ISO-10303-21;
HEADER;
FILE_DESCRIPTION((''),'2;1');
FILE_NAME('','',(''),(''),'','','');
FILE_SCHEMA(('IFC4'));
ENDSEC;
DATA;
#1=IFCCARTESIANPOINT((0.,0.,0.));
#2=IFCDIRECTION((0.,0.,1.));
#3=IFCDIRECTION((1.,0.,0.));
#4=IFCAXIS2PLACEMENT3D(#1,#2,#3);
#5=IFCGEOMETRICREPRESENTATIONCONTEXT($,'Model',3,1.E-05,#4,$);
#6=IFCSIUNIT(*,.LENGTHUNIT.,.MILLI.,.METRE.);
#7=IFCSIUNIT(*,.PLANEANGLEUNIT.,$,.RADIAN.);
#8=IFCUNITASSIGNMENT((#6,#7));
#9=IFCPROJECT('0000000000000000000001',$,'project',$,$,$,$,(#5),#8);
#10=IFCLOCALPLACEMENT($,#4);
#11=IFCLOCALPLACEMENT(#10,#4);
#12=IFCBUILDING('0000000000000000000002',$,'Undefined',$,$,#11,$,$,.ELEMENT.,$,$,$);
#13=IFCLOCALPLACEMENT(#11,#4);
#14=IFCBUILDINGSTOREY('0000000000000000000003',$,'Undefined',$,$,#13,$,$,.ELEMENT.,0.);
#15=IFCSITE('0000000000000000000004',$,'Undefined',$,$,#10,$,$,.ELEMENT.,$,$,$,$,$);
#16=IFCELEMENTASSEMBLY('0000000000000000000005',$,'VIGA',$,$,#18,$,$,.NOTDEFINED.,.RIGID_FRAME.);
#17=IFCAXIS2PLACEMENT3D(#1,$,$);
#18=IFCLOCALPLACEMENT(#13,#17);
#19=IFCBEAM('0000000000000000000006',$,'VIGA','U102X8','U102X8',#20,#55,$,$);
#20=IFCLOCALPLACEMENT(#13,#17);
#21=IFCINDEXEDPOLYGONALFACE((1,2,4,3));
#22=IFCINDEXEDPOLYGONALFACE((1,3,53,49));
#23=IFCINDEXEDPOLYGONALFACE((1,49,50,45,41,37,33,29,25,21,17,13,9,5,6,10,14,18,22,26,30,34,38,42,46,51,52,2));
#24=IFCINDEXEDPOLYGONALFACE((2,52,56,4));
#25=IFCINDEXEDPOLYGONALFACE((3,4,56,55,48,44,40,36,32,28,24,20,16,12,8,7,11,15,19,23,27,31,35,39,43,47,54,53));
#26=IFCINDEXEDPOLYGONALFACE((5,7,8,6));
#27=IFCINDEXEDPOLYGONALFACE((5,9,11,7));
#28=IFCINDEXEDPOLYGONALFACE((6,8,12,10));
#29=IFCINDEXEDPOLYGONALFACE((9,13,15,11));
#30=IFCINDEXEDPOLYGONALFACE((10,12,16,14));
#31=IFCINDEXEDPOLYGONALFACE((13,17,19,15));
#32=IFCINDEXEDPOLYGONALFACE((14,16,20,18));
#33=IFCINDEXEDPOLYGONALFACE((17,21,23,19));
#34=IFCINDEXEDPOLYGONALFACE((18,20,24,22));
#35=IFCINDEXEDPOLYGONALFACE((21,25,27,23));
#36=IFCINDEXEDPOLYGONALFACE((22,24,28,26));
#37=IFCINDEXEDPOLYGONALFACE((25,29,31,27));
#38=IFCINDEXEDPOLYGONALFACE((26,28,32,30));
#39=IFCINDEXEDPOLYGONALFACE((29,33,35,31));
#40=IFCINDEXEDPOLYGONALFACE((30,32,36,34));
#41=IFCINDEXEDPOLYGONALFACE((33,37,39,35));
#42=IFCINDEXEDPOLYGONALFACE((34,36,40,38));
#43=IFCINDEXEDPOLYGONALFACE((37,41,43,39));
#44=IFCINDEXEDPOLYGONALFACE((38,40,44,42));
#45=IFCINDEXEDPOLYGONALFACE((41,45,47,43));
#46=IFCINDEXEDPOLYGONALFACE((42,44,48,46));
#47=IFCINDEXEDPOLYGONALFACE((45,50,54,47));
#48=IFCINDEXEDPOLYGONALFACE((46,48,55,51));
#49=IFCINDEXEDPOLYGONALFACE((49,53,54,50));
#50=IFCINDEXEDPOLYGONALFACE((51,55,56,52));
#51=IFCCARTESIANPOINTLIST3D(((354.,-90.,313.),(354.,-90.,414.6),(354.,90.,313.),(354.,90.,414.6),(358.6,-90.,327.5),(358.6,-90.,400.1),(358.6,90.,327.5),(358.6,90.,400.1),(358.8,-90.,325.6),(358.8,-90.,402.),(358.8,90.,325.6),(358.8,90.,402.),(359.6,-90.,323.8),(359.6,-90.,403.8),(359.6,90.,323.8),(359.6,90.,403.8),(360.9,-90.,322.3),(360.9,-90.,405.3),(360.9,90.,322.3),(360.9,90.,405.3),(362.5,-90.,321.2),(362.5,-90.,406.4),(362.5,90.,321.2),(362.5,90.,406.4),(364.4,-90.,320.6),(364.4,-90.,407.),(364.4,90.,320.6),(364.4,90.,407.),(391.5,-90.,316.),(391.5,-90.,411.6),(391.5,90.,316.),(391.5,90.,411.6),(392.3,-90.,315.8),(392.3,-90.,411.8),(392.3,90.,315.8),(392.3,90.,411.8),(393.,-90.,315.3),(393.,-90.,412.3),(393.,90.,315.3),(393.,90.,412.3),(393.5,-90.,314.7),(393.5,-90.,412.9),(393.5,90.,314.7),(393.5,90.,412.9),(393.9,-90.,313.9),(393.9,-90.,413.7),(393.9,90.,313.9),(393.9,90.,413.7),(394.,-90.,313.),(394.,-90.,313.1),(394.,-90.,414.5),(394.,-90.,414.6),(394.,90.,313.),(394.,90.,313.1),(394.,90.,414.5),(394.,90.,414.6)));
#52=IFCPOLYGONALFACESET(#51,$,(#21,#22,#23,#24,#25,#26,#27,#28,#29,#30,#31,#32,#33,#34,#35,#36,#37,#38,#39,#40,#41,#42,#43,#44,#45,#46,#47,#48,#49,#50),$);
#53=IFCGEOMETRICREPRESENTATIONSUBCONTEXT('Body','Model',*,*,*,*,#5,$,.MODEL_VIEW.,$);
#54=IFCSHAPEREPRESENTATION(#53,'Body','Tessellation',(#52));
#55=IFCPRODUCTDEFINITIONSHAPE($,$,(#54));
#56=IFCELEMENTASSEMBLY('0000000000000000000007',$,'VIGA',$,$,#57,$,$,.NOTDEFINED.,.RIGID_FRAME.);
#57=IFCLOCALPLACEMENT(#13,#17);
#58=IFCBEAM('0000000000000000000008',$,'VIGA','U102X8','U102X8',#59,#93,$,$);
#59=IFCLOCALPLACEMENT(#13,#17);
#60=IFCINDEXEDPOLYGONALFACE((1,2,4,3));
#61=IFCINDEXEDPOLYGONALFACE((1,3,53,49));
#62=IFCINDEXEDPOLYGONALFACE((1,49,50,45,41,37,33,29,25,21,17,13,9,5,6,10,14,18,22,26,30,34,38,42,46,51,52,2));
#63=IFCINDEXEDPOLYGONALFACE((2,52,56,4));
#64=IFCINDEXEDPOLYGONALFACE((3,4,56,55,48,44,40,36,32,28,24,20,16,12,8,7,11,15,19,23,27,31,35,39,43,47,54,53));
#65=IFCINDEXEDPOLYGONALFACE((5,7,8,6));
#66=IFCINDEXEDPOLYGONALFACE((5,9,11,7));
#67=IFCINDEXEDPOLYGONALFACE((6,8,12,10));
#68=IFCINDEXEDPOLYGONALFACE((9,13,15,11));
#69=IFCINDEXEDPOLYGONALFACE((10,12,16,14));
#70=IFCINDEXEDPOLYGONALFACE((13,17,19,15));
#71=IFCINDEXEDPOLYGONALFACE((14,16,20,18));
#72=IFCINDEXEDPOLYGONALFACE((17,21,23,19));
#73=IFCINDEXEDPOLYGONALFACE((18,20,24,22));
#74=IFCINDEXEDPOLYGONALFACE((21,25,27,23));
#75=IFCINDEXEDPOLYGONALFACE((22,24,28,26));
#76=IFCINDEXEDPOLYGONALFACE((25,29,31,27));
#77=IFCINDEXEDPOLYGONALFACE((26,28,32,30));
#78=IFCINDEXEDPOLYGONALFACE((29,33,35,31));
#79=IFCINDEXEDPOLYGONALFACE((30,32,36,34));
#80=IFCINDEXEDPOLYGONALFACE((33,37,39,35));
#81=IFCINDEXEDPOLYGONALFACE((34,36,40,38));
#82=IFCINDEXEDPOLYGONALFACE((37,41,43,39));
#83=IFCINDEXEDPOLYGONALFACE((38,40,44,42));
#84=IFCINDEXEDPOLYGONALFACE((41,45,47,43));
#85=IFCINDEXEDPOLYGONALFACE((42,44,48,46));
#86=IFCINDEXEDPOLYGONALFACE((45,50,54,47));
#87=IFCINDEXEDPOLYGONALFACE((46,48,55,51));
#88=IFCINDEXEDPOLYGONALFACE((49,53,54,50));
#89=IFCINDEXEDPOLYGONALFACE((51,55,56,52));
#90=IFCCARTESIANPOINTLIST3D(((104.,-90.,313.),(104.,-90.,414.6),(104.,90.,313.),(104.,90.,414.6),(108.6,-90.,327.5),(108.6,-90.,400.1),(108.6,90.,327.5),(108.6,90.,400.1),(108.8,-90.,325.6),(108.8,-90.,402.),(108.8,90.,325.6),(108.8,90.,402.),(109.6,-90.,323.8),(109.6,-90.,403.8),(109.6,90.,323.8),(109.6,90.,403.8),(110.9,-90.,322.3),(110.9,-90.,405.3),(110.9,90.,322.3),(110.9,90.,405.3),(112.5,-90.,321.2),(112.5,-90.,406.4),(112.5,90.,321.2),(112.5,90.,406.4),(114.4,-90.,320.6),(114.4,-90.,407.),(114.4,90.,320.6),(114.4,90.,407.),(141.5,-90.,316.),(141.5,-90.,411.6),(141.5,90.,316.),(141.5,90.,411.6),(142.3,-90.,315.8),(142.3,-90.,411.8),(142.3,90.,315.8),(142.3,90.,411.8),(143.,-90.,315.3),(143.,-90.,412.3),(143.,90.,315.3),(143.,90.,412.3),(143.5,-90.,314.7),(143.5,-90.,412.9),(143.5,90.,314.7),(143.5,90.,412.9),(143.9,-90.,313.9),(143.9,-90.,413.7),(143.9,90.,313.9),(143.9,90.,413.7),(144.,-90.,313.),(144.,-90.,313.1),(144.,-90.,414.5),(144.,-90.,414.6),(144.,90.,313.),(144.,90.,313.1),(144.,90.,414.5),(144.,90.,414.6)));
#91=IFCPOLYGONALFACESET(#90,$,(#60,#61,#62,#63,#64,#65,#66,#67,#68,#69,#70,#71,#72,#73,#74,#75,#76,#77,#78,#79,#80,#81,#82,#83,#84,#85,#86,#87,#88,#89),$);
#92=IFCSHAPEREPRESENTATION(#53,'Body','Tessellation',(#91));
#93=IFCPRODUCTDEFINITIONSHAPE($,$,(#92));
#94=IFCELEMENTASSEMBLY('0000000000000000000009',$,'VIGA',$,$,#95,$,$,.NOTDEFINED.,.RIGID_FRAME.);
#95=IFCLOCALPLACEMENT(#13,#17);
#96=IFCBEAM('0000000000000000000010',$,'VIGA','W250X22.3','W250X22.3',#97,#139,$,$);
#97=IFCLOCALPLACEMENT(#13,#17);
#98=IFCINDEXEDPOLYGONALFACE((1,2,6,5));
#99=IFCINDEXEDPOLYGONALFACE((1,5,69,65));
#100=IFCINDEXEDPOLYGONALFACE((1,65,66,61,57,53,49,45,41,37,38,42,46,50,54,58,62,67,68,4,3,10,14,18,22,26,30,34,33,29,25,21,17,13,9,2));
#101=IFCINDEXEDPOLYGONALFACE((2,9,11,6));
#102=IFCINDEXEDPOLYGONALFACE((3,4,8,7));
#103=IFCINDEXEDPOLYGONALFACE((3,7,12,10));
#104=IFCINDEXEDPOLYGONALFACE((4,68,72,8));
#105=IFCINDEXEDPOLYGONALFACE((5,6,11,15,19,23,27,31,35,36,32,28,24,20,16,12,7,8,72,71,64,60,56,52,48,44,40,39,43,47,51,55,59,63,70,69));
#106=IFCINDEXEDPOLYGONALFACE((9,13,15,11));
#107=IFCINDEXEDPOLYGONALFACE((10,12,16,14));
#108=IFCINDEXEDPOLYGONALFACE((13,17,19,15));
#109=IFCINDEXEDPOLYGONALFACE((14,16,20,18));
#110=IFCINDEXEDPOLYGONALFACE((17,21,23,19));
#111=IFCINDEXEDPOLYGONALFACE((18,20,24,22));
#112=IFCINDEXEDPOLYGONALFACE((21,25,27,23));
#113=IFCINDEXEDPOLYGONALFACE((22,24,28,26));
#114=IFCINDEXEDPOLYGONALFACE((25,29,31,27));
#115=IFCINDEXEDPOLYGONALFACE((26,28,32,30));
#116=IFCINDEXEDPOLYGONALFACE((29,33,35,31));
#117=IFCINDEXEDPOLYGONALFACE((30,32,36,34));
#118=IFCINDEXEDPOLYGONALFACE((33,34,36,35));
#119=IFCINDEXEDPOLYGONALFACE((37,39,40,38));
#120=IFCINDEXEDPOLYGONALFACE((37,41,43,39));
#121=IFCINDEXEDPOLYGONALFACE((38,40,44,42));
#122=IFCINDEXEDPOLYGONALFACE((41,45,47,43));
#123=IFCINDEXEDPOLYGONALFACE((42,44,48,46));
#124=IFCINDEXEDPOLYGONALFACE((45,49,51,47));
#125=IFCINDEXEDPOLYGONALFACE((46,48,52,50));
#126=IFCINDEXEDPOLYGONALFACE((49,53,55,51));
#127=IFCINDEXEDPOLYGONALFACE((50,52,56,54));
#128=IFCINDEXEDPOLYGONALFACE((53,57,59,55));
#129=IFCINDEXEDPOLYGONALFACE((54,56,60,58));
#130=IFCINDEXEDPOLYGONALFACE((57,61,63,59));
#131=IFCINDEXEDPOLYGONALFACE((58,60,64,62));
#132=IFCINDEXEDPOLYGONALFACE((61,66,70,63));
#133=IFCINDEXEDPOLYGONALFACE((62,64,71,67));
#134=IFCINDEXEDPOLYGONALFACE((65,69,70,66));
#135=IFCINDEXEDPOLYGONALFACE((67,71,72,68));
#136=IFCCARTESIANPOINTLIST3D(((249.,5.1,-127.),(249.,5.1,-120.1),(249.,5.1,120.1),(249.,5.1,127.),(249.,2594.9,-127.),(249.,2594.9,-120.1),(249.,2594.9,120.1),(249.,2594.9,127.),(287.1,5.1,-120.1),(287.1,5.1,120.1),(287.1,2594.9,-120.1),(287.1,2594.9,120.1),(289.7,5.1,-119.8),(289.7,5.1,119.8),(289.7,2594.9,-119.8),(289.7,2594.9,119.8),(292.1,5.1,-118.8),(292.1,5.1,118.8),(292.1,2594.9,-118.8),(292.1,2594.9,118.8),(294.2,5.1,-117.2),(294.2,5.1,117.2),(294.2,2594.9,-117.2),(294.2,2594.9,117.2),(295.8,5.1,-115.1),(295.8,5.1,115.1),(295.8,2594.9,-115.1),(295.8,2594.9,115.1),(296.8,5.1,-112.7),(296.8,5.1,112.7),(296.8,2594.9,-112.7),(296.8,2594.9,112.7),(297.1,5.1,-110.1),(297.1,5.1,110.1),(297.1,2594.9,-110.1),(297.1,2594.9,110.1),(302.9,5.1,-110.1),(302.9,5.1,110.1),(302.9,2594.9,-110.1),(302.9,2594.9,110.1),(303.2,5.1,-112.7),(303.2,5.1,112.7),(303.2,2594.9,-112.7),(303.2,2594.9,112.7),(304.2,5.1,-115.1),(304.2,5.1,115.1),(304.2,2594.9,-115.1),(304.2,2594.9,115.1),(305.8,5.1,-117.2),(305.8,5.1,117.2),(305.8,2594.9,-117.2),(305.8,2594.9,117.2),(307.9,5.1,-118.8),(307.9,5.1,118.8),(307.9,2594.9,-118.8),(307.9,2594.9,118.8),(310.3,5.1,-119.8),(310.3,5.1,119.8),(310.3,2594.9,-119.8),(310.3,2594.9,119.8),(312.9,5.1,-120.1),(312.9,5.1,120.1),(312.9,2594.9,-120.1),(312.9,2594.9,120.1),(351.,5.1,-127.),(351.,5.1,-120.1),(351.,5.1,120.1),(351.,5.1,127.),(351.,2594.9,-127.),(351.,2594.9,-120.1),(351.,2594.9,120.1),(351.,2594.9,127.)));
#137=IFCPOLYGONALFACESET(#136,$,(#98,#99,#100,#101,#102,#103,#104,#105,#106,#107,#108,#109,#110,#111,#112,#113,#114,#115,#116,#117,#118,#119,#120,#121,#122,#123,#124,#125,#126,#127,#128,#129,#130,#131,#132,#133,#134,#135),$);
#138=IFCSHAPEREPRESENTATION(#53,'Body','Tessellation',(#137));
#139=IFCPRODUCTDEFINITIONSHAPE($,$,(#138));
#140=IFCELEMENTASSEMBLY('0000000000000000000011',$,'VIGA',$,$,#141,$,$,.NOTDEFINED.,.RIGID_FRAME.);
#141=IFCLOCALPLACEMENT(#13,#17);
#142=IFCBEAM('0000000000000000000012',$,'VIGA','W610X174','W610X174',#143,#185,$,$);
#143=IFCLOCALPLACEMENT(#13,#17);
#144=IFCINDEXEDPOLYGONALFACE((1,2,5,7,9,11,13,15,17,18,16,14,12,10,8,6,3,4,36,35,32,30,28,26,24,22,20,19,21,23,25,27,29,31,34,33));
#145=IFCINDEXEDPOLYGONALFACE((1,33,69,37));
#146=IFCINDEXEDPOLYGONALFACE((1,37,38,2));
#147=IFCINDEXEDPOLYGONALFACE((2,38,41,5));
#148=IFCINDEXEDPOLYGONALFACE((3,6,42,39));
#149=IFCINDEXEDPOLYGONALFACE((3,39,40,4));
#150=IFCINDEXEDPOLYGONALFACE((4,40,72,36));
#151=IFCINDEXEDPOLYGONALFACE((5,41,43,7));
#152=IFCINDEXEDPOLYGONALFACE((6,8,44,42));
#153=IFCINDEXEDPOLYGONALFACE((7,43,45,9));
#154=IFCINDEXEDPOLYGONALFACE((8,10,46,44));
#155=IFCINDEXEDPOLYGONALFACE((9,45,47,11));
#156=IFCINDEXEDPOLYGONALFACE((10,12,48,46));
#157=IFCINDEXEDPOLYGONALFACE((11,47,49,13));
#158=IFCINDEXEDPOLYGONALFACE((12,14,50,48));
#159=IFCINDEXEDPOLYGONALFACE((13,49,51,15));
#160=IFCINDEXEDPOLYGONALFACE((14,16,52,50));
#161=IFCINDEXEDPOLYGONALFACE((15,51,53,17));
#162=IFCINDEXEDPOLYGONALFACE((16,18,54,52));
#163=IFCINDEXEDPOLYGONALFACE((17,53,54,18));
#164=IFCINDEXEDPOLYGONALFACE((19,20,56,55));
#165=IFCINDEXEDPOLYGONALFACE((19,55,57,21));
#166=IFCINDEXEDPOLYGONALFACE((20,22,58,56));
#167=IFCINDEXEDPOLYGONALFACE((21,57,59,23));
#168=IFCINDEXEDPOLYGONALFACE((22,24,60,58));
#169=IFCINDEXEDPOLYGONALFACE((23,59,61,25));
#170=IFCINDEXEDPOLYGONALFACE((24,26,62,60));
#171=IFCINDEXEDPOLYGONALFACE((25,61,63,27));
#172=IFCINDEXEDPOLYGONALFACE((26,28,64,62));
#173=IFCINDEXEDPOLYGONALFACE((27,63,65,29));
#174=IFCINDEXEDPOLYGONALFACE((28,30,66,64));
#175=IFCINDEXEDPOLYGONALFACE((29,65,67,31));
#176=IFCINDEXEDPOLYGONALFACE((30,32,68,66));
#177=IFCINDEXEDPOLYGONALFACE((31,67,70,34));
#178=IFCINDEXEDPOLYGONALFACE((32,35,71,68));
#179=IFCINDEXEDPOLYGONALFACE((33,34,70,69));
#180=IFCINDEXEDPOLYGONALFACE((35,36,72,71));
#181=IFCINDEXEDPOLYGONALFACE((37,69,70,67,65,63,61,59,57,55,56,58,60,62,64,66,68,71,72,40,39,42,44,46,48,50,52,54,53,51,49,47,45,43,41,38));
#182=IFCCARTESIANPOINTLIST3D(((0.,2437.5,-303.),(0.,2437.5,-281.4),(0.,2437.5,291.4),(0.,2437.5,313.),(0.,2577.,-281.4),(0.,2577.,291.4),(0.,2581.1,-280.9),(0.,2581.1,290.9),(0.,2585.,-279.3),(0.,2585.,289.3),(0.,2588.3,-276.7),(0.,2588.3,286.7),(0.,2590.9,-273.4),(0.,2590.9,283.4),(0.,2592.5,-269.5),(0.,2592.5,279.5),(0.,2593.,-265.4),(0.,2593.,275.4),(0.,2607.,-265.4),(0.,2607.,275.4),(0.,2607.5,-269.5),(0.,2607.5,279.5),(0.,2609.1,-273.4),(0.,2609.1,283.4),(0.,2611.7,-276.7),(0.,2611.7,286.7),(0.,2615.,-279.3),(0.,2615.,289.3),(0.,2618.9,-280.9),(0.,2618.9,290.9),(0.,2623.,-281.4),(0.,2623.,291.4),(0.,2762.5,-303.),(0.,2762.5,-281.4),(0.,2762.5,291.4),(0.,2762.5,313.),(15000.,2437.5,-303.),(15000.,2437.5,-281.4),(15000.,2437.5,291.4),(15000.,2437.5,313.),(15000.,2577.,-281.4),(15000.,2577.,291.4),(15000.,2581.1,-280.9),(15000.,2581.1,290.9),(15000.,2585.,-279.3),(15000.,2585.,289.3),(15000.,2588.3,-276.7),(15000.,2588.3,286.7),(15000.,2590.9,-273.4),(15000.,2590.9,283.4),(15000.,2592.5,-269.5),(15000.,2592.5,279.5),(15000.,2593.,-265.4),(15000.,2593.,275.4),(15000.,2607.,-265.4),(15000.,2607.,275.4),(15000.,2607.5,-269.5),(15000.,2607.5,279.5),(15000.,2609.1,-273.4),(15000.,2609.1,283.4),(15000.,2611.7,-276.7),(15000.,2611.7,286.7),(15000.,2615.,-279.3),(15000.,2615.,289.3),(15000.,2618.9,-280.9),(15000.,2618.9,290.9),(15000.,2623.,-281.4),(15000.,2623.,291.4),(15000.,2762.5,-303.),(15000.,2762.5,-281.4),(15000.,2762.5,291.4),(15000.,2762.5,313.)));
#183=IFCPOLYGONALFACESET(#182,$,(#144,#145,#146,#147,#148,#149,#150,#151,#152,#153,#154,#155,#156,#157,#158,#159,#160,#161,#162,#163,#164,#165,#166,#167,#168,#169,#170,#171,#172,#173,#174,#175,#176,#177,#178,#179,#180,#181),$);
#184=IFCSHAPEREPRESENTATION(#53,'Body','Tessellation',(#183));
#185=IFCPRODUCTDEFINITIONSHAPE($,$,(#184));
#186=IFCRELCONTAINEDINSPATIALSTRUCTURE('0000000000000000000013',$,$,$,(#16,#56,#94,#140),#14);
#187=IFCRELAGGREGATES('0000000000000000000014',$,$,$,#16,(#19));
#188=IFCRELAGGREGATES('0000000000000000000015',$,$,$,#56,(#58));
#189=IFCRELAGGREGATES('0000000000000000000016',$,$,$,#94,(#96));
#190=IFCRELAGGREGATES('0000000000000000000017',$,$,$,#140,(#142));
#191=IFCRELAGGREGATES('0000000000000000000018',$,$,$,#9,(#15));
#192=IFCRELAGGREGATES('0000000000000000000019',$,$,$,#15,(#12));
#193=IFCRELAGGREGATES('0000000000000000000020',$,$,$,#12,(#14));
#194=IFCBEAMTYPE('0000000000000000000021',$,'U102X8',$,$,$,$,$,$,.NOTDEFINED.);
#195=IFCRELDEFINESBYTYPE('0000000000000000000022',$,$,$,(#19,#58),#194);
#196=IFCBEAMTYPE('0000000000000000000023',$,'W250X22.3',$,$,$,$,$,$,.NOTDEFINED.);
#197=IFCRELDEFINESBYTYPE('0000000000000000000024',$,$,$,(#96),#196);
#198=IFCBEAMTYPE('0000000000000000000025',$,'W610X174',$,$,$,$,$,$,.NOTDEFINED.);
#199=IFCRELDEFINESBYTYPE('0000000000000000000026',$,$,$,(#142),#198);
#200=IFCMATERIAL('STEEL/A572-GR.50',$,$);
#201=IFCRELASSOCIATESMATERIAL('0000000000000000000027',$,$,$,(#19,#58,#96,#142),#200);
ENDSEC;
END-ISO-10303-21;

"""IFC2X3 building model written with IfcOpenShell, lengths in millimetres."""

from ifc_helpers import new_model, si_unit, frame, origin_with_axes, origin_2d_with_axis, place, context, subcontext, project, spatial, i_section, u_section, extrude, material, type_object, element, aggregate, save


model = new_model("IFC2X3")

# Units and contexts
model_context = context("Model", 3, precision=1e-05, world=origin_with_axes())
body_context = subcontext(model_context, "Body", "Model", "MODEL_VIEW")
ifc_project = project(units=[si_unit("LENGTHUNIT", "METRE", prefix="MILLI"), si_unit("PLANEANGLEUNIT", "RADIAN")], contexts=[model_context])

# Site, building, storey
site_placement = place(None, origin_with_axes())
site = spatial("IfcSite", under=ifc_project, at=site_placement, Name="Undefined", CompositionType="ELEMENT")
building_placement = place(site_placement, origin_with_axes())
building = spatial("IfcBuilding", under=site, at=building_placement, Name="Undefined", CompositionType="ELEMENT")
storey_placement = place(building_placement, origin_with_axes())
storey = spatial("IfcBuildingStorey", under=building, at=storey_placement, Name="Undefined", CompositionType="ELEMENT", Elevation=0.0)

# Element assemblies, beams
ifc_material_1 = material(Name="STEEL/A572-GR.50")
beam_type_1 = type_object("IfcBeamType", Name="U102X8", PredefinedType="NOTDEFINED")
assembly_1_placement = place(storey_placement, origin_with_axes())
assembly_1 = element("IfcElementAssembly", 1, at=assembly_1_placement, inside=storey, Name="VIGA", AssemblyPlace="NOTDEFINED", PredefinedType="RIGID_FRAME")
beam_1_placement = place(assembly_1_placement, frame((374.0, -90.0, 363.8), z_axis=(0.0, 0.0, 1.0), x_axis=(0.0, 1.0, 0.0)))
beam_1 = element("IfcBeam", 2, at=beam_1_placement, type_object=beam_type_1, material=ifc_material_1, Name="VIGA", Description="U102X8", ObjectType="U102X8", context=body_context, shape_type="SweptSolid", body=[
    extrude(u_section(Depth=101.6, FlangeWidth=40.0, WebThickness=4.6, FlangeThickness=6.0, FilletRadius=7.0, EdgeRadius=3.0, FlangeSlope=0.16839, at=origin_2d_with_axis()), frame((180.0, 0.0, 0.0), z_axis=(-1.0, 0.0, 0.0), x_axis=(0.0, -1.0, 0.0)), (0.0, 0.0, 1.0), 180.0),
])
aggregate(assembly_1, [beam_1])
assembly_2_placement = place(storey_placement, origin_with_axes())
assembly_2 = element("IfcElementAssembly", 3, at=assembly_2_placement, inside=storey, Name="VIGA", AssemblyPlace="NOTDEFINED", PredefinedType="RIGID_FRAME")
beam_2_placement = place(assembly_2_placement, frame((124.0, -90.0, 363.8), z_axis=(0.0, 0.0, 1.0), x_axis=(0.0, 1.0, 0.0)))
beam_2 = element("IfcBeam", 4, at=beam_2_placement, type_object=beam_type_1, material=ifc_material_1, Name="VIGA", Description="U102X8", ObjectType="U102X8", context=body_context, shape_type="SweptSolid", body=[
    extrude(u_section(Depth=101.6, FlangeWidth=40.0, WebThickness=4.6, FlangeThickness=6.0, FilletRadius=7.0, EdgeRadius=3.0, FlangeSlope=0.16839, at=origin_2d_with_axis()), frame((180.0, 0.0, 0.0), z_axis=(-1.0, 0.0, 0.0), x_axis=(0.0, -1.0, 0.0)), (0.0, 0.0, 1.0), 180.0),
])
aggregate(assembly_2, [beam_2])
assembly_3_placement = place(storey_placement, origin_with_axes())
assembly_3 = element("IfcElementAssembly", 5, at=assembly_3_placement, inside=storey, Name="VIGA", AssemblyPlace="NOTDEFINED", PredefinedType="RIGID_FRAME")
beam_type_2 = type_object("IfcBeamType", Name="W250X22.3", PredefinedType="NOTDEFINED")
beam_3_placement = place(assembly_3_placement, frame((300.0, 5.1, 0.0), z_axis=(0.0, 0.0, 1.0), x_axis=(0.0, 1.0, 0.0)))
beam_3 = element("IfcBeam", 6, at=beam_3_placement, type_object=beam_type_2, material=ifc_material_1, Name="VIGA", Description="W250X22.3", ObjectType="W250X22.3", context=body_context, shape_type="SweptSolid", body=[
    extrude(i_section(OverallWidth=102.0, OverallDepth=254.0, WebThickness=5.8, FlangeThickness=6.9, FilletRadius=10.0, at=origin_2d_with_axis()), frame((2589.8, 0.0, 0.0), z_axis=(-1.0, 0.0, 0.0), x_axis=(0.0, -1.0, 0.0)), (0.0, 0.0, 1.0), 2589.8),
])
aggregate(assembly_3, [beam_3])
assembly_4_placement = place(storey_placement, origin_with_axes())
assembly_4 = element("IfcElementAssembly", 7, at=assembly_4_placement, inside=storey, Name="VIGA", AssemblyPlace="NOTDEFINED", PredefinedType="RIGID_FRAME")
beam_type_3 = type_object("IfcBeamType", Name="W610X174", PredefinedType="NOTDEFINED")
beam_4_placement = place(assembly_4_placement, frame((0.0, 2600.0, 5.0), z_axis=(0.0, 0.0, 1.0), x_axis=(1.0, 0.0, 0.0)))
beam_4 = element("IfcBeam", 8, at=beam_4_placement, type_object=beam_type_3, material=ifc_material_1, Name="VIGA", Description="W610X174", ObjectType="W610X174", context=body_context, shape_type="SweptSolid", body=[
    extrude(i_section(OverallWidth=325.0, OverallDepth=616.0, WebThickness=14.0, FlangeThickness=21.6, FilletRadius=16.0, at=origin_2d_with_axis()), frame((15000.0, 0.0, 0.0), z_axis=(-1.0, 0.0, 0.0), x_axis=(0.0, -1.0, 0.0)), (0.0, 0.0, 1.0), 15000.0),
])
aggregate(assembly_4, [beam_4])

save(model, "model.ifc")
